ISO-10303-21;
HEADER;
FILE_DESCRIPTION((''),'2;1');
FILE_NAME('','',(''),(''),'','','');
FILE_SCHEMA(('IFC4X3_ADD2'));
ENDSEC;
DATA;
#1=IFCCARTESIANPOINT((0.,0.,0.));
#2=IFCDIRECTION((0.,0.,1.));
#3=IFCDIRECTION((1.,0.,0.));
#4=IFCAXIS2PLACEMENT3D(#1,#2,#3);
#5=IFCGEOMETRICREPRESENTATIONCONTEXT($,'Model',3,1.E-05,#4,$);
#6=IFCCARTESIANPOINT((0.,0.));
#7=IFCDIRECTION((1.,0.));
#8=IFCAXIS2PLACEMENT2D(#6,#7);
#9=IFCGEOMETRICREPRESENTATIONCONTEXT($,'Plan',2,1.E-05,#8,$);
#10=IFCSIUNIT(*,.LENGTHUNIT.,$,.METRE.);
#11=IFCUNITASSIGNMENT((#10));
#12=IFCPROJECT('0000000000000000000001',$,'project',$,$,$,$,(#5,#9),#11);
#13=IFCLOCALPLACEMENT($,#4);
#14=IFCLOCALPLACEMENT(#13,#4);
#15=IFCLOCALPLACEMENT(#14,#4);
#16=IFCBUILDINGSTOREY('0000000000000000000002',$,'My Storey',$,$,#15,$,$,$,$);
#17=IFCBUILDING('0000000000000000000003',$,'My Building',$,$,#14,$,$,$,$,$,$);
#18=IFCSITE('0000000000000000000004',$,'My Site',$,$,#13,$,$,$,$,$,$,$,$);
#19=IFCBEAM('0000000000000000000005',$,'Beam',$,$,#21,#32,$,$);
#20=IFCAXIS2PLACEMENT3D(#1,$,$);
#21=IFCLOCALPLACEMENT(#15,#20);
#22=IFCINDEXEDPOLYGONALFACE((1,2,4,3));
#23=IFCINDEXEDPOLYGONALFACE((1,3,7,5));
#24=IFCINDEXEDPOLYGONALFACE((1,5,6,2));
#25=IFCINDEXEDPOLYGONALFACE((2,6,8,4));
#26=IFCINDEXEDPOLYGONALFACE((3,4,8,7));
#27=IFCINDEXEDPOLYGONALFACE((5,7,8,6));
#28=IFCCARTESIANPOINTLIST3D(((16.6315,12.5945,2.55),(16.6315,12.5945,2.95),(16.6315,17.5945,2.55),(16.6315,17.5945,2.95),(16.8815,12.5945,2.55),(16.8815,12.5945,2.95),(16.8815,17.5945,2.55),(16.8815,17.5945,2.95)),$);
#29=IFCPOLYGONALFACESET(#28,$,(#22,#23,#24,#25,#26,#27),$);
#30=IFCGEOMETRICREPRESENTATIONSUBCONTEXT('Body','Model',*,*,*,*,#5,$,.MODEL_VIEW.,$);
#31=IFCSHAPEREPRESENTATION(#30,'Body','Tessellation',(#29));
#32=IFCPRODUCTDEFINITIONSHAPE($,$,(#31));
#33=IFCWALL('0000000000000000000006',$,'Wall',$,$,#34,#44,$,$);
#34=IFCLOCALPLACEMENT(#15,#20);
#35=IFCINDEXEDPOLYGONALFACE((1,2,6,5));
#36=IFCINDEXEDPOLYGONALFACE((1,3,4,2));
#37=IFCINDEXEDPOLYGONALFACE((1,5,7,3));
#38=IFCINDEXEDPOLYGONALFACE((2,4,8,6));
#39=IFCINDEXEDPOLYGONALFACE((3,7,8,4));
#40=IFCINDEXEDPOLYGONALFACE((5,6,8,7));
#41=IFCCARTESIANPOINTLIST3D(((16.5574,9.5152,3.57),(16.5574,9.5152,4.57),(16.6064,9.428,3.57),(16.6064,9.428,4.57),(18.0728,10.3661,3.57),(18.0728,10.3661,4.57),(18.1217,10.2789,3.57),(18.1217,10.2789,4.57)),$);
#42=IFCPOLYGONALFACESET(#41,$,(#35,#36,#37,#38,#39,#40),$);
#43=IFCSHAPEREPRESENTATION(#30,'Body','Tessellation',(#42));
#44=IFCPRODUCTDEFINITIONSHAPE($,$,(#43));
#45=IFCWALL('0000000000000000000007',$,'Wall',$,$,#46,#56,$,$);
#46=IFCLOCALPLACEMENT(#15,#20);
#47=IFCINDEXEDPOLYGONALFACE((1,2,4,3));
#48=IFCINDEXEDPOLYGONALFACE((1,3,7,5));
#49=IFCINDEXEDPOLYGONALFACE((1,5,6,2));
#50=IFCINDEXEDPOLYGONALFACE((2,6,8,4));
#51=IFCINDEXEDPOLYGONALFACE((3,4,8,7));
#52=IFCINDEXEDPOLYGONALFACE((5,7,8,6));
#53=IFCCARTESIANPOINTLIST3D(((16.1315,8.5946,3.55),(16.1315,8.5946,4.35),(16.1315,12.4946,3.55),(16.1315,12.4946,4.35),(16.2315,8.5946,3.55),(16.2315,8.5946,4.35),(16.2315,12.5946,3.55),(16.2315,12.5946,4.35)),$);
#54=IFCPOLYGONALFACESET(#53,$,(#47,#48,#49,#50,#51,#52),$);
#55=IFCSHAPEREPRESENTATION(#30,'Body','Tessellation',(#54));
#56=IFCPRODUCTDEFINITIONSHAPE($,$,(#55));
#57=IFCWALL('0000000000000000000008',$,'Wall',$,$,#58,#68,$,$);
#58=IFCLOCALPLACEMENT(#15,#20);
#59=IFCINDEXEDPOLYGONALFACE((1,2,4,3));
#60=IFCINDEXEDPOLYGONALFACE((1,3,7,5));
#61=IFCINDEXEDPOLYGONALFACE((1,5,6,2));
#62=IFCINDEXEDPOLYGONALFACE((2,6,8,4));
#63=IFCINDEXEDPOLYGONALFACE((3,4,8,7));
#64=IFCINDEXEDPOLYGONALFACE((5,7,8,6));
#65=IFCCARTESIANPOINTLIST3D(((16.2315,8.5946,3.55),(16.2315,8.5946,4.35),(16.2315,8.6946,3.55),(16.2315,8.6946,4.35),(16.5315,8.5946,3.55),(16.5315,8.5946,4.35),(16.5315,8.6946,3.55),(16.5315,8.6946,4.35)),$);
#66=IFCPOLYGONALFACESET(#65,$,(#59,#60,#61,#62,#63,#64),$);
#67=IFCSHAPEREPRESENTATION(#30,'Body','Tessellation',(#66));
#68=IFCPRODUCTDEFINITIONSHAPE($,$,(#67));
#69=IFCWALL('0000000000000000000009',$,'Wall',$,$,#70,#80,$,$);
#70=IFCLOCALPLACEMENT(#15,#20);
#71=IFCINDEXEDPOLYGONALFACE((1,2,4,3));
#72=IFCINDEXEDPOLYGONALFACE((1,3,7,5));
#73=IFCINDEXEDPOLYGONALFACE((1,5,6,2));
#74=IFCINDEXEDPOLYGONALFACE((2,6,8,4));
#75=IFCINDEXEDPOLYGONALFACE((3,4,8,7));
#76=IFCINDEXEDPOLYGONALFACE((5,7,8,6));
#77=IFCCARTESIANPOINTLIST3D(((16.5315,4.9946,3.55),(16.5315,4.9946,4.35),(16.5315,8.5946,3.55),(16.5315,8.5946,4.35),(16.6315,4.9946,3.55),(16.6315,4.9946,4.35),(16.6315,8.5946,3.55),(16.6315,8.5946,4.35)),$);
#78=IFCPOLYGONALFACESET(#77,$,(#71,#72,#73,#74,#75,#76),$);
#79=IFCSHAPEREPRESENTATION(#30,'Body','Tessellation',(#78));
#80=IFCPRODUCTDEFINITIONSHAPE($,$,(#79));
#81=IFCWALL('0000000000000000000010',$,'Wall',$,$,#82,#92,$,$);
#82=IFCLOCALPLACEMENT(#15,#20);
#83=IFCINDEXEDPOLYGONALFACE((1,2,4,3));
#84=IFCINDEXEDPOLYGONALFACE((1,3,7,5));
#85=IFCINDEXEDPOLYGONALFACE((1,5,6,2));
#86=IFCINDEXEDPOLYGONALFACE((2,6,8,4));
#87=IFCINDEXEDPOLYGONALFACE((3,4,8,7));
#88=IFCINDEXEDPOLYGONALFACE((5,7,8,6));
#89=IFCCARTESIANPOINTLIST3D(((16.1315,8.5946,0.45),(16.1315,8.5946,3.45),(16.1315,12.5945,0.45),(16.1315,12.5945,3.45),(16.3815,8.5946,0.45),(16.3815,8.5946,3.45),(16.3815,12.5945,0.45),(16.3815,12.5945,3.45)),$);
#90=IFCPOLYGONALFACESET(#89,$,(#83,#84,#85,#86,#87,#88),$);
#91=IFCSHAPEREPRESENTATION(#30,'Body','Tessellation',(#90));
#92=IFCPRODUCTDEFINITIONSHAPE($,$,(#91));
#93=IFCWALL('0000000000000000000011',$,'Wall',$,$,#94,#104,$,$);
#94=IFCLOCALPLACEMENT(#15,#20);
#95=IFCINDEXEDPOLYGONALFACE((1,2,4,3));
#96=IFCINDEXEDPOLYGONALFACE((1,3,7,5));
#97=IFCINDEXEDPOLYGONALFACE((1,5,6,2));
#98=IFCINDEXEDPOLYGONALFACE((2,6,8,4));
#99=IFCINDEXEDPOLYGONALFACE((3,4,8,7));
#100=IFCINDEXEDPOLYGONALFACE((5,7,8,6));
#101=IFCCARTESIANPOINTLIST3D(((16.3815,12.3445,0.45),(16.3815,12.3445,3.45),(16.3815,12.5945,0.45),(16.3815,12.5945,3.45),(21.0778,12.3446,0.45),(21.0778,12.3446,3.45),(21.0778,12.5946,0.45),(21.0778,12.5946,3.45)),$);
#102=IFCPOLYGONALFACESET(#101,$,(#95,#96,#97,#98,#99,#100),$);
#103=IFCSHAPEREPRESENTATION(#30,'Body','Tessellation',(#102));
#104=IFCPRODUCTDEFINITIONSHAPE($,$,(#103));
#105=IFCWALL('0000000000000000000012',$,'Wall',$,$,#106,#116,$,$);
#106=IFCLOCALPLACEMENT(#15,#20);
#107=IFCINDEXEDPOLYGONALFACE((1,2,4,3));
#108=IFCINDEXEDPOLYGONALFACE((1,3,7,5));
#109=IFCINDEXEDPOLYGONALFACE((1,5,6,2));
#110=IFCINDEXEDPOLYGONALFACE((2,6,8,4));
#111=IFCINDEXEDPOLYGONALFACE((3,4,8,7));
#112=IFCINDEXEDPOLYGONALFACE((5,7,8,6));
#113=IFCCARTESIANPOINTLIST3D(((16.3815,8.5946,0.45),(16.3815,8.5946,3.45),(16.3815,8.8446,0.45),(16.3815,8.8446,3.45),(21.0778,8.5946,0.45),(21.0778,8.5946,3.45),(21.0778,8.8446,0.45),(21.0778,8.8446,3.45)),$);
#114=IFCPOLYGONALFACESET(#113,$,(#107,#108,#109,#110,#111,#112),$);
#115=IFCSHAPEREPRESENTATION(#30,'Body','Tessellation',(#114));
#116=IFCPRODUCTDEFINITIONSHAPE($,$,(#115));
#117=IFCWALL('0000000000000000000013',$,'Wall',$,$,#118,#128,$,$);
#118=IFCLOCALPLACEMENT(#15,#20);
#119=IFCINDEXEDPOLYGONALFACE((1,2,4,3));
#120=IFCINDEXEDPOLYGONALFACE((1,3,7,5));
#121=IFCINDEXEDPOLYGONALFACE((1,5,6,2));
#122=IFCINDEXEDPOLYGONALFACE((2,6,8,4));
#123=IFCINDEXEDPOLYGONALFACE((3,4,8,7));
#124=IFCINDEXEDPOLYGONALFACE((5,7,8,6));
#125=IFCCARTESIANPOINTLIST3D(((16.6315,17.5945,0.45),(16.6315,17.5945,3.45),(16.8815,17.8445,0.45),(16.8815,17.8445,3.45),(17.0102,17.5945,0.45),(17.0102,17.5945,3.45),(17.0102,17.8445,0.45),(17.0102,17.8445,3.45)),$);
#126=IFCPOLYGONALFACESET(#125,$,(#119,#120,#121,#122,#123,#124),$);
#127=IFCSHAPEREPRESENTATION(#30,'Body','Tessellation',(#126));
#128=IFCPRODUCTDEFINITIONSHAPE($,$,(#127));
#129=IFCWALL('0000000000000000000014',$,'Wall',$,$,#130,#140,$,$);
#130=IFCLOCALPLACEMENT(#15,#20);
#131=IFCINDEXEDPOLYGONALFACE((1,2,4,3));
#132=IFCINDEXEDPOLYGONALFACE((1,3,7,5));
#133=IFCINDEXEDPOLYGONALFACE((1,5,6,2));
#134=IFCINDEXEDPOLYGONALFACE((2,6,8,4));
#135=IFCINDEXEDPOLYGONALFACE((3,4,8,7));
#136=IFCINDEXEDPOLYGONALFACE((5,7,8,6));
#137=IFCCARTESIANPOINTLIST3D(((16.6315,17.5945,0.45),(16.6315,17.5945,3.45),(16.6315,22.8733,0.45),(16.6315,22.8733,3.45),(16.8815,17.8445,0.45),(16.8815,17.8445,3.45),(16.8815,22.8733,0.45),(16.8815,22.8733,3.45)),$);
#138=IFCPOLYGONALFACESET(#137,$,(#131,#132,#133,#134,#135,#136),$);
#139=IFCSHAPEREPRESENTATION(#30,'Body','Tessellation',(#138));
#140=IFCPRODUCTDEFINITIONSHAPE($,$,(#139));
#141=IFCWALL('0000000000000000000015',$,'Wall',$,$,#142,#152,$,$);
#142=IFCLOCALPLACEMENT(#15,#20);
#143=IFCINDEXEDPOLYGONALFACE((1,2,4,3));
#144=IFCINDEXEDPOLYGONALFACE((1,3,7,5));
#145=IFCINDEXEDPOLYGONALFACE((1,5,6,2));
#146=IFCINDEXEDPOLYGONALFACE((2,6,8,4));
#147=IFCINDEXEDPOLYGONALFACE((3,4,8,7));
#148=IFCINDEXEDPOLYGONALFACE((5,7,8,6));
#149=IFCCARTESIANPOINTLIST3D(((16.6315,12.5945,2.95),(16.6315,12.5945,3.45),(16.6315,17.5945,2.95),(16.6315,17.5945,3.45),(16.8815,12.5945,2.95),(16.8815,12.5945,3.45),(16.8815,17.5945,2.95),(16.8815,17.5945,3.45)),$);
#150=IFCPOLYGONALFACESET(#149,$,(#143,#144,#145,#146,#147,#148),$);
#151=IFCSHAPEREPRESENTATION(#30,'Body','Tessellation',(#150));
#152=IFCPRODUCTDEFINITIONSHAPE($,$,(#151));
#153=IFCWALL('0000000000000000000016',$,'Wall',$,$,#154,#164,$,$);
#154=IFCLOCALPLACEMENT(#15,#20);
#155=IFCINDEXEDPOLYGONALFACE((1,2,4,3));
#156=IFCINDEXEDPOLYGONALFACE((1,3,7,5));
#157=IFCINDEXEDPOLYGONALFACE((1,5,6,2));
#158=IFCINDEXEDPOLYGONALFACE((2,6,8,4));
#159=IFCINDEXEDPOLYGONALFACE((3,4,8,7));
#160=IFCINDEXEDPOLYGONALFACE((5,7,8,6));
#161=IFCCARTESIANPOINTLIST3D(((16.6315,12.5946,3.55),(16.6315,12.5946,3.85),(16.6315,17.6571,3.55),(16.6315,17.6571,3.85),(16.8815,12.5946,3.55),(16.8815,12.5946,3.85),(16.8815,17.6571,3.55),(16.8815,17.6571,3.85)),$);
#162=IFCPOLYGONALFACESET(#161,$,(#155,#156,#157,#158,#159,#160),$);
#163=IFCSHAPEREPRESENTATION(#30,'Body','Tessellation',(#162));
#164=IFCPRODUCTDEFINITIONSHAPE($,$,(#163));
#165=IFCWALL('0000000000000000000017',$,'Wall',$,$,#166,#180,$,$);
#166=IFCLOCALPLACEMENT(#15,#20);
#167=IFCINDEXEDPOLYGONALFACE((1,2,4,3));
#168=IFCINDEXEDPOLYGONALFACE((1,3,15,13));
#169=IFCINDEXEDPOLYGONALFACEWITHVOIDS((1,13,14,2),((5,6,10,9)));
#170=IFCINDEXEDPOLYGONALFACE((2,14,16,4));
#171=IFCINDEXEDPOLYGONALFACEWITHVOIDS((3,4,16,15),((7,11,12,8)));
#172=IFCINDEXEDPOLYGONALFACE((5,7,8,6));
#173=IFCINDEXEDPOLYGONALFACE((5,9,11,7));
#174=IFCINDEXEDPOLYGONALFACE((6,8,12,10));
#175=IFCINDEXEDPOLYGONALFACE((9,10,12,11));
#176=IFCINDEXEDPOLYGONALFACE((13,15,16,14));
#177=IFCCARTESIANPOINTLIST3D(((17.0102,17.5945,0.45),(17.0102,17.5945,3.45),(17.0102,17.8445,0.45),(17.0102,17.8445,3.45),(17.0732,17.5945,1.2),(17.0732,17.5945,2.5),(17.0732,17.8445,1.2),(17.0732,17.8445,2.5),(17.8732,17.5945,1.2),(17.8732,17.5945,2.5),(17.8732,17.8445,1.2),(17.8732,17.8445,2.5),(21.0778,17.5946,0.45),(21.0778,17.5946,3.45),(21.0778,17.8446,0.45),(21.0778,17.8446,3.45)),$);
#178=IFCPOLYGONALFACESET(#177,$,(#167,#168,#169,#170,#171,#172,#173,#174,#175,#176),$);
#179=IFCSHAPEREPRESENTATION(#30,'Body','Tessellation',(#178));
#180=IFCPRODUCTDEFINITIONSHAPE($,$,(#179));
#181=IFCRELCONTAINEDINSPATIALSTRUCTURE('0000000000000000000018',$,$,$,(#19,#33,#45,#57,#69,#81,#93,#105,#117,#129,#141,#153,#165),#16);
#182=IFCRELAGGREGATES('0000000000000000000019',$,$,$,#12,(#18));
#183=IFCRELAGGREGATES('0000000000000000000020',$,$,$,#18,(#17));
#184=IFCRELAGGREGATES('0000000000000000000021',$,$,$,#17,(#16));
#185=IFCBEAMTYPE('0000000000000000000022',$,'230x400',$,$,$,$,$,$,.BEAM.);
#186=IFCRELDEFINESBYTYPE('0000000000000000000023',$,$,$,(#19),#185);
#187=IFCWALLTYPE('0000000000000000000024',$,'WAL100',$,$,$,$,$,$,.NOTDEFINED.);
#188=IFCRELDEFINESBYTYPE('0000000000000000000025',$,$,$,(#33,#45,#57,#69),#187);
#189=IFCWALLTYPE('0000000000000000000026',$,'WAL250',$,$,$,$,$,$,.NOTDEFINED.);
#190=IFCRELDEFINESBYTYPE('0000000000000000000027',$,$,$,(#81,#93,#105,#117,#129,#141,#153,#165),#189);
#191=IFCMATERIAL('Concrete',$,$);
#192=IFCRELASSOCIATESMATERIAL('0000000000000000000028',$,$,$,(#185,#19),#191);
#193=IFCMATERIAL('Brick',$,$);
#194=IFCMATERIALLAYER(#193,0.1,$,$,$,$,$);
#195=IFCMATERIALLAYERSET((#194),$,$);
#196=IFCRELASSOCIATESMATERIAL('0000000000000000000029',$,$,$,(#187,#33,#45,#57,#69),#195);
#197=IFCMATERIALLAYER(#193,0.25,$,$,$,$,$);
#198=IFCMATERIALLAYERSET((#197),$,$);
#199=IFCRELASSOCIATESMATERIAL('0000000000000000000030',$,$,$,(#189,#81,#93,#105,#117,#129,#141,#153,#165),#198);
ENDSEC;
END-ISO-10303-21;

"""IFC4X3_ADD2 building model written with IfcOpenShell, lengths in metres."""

from ifc_helpers import new_model, si_unit, frame, origin_with_axes, origin_2d_with_axis, place, context, subcontext, project, spatial, line, indexed_curve, rectangle, outline, extrude, source, transform, mapped, material, layer, layer_set, layer_usage, material_profile, profile_set, profile_usage, type_object, element, save


model = new_model("IFC4X3_ADD2")

# Units and contexts
model_context = context("Model", 3, precision=1e-05, world=origin_with_axes())
plan_context = context("Plan", 2, precision=1e-05, world=origin_2d_with_axis())
body_context = subcontext(model_context, "Body", "Model", "MODEL_VIEW")
ifc_project = project(units=[si_unit("LENGTHUNIT", "METRE")], contexts=[model_context, plan_context])

# Site, building, storey
site_placement = place(None, origin_with_axes())
site = spatial("IfcSite", under=ifc_project, at=site_placement, Name="My Site")
building_placement = place(site_placement, origin_with_axes())
building = spatial("IfcBuilding", under=site, at=building_placement, Name="My Building")
storey_placement = place(building_placement, origin_with_axes())
storey = spatial("IfcBuildingStorey", under=building, at=storey_placement, Name="My Storey")

# Beam
ifc_material_1 = material(Name="Concrete")
ifc_material_profile = material_profile(ifc_material_1, rectangle(XDim=0.25, YDim=0.4))
ifc_profile_set = profile_set([ifc_material_profile])
ifc_profile_usage = profile_usage(ifc_profile_set, cardinal=5)
beam_type = type_object("IfcBeamType", Name="230x400", PredefinedType="BEAM", material=ifc_profile_set)
beam_placement = place(storey_placement, frame((16.7565, 12.5945, 2.75), z_axis=(0.0, 1.0, 0.0), x_axis=(-1.0, 0.0, 0.0)))
element("IfcBeam", 1, at=beam_placement, inside=storey, type_object=beam_type, material=ifc_profile_usage, Name="Beam", context=body_context, shape_type="SweptSolid", body=[
    extrude(rectangle(XDim=0.25, YDim=0.4), origin_with_axes(), (0.0, 0.0, 1.0), 5.0),
])

# Walls
ifc_material_2 = material(Name="Brick")
ifc_layer_1 = layer(ifc_material_2, 0.1)
ifc_layer_set_1 = layer_set([ifc_layer_1])
ifc_layer_usage_1 = layer_usage(ifc_layer_set_1, "AXIS2", "POSITIVE", 0.0)
wall_type_1 = type_object("IfcWallType", Name="WAL100", PredefinedType="NOTDEFINED", material=ifc_layer_set_1)
wall_1_placement = place(storey_placement, frame((16.6064, 9.428, 3.57), z_axis=(0.0, 0.0, 1.0), x_axis=(0.871953, 0.489589, 0.0)))
element("IfcWall", 2, at=wall_1_placement, inside=storey, type_object=wall_type_1, material=ifc_layer_usage_1, Name="Wall", context=body_context, shape_type="SweptSolid", body=[
    extrude(outline(indexed_curve([(0.0, 0.0), (0.0, 0.1), (1.7379, 0.1), (1.7379, 0.0)], segments=[line(1, 2, 3, 4, 1)])), origin_with_axes(), (0.0, 0.0, 1.0), 1.0),
])
ifc_layer_usage_2 = layer_usage(ifc_layer_set_1, "AXIS2", "POSITIVE", 0.0)
wall_2_placement = place(storey_placement, frame((16.2315, 8.5946, 3.55), z_axis=(0.0, 0.0, 1.0), x_axis=(-0.000006, 1.0, 0.0)))
element("IfcWall", 3, at=wall_2_placement, inside=storey, type_object=wall_type_1, material=ifc_layer_usage_2, Name="Wall", context=body_context, shape_type="SweptSolid", body=[
    extrude(outline(indexed_curve([(0.0, 0.0), (0.0, 0.1), (3.9, 0.1), (4.0, 0.0)], segments=[line(1, 2, 3, 4, 1)])), origin_with_axes(), (0.0, 0.0, 1.0), 0.8),
])
ifc_layer_usage_3 = layer_usage(ifc_layer_set_1, "AXIS2", "POSITIVE", 0.0)
wall_3_placement = place(storey_placement, frame((16.2315, 8.5946, 3.55), z_axis=(0.0, 0.0, 1.0), x_axis=(1.0, 0.000005, 0.0)))
element("IfcWall", 4, at=wall_3_placement, inside=storey, type_object=wall_type_1, material=ifc_layer_usage_3, Name="Wall", context=body_context, shape_type="SweptSolid", body=[
    extrude(outline(indexed_curve([(0.0, 0.0), (0.0, 0.1), (0.3, 0.1), (0.3, 0.0)], segments=[line(1, 2, 3, 4, 1)])), origin_with_axes(), (0.0, 0.0, 1.0), 0.8),
])
ifc_layer_usage_4 = layer_usage(ifc_layer_set_1, "AXIS2", "POSITIVE", 0.0)
wall_4_placement = place(storey_placement, frame((16.5315, 8.5946, 3.55), z_axis=(0.0, 0.0, 1.0), x_axis=(0.000005, -1.0, 0.0)))
element("IfcWall", 5, at=wall_4_placement, inside=storey, type_object=wall_type_1, material=ifc_layer_usage_4, Name="Wall", context=body_context, shape_type="SweptSolid", body=[
    extrude(outline(indexed_curve([(0.0, 0.0), (0.0, 0.1), (3.6, 0.1), (3.6, 0.0)], segments=[line(1, 2, 3, 4, 1)])), origin_with_axes(), (0.0, 0.0, 1.0), 0.8),
])
ifc_layer_2 = layer(ifc_material_2, 0.25)
ifc_layer_set_2 = layer_set([ifc_layer_2])
ifc_layer_usage_5 = layer_usage(ifc_layer_set_2, "AXIS2", "NEGATIVE", 0.0)
wall_type_2 = type_object("IfcWallType", Name="WAL250", PredefinedType="NOTDEFINED", material=ifc_layer_set_2)
wall_5_placement = place(storey_placement, frame((16.1315, 8.5946, 0.45), z_axis=(0.0, 0.0, 1.0), x_axis=(0.0, 1.0, 0.0)))
element("IfcWall", 6, at=wall_5_placement, inside=storey, type_object=wall_type_2, material=ifc_layer_usage_5, Name="Wall", context=body_context, shape_type="SweptSolid", body=[
    extrude(outline(indexed_curve([(0.0, -0.25), (0.0, 0.0), (4.0, 0.0), (4.0, -0.25)], segments=[line(1, 2, 3, 4, 1)])), origin_with_axes(), (0.0, 0.0, 1.0), 3.0),
])
ifc_layer_usage_6 = layer_usage(ifc_layer_set_2, "AXIS2", "POSITIVE", 0.0)
wall_6_placement = place(storey_placement, frame((16.3815, 12.3445, 0.45), z_axis=(0.0, 0.0, 1.0), x_axis=(1.0, 0.000006, 0.0)))
element("IfcWall", 7, at=wall_6_placement, inside=storey, type_object=wall_type_2, material=ifc_layer_usage_6, Name="Wall", context=body_context, shape_type="SweptSolid", body=[
    extrude(outline(indexed_curve([(0.0, 0.0), (0.0, 0.25), (4.6964, 0.25), (4.6964, 0.0)], segments=[line(1, 2, 3, 4, 1)])), origin_with_axes(), (0.0, 0.0, 1.0), 3.0),
])
ifc_layer_usage_7 = layer_usage(ifc_layer_set_2, "AXIS2", "POSITIVE", 0.0)
wall_7_placement = place(storey_placement, frame((16.3815, 8.5946, 0.45), z_axis=(0.0, 0.0, 1.0), x_axis=(1.0, 0.000006, 0.0)))
element("IfcWall", 8, at=wall_7_placement, inside=storey, type_object=wall_type_2, material=ifc_layer_usage_7, Name="Wall", context=body_context, shape_type="SweptSolid", body=[
    extrude(outline(indexed_curve([(0.0, 0.0), (0.0, 0.25), (4.6964, 0.25), (4.6964, 0.0)], segments=[line(1, 2, 3, 4, 1)])), origin_with_axes(), (0.0, 0.0, 1.0), 3.0),
])
ifc_layer_usage_8 = layer_usage(ifc_layer_set_2, "AXIS2", "POSITIVE", 0.0)
wall_8_placement = place(storey_placement, frame((16.8815, 17.5945, 0.45), z_axis=(0.0, 0.0, 1.0), x_axis=(1.0, 0.000006, 0.0)))
element("IfcWall", 9, at=wall_8_placement, inside=storey, type_object=wall_type_2, material=ifc_layer_usage_8, Name="Wall", context=body_context, shape_type="SweptSolid", body=[
    extrude(outline(indexed_curve([(-0.25, 0.0), (0.0, 0.25), (0.1287, 0.25), (0.1287, 0.0)], segments=[line(1, 2, 3, 4, 1)])), origin_with_axes(), (0.0, 0.0, 1.0), 3.0),
])
ifc_layer_usage_9 = layer_usage(ifc_layer_set_2, "AXIS2", "POSITIVE", 0.0)
wall_9_placement = place(storey_placement, frame((16.8815, 17.5945, 0.45), z_axis=(0.0, 0.0, 1.0), x_axis=(-0.000006, 1.0, 0.0)))
element("IfcWall", 10, at=wall_9_placement, inside=storey, type_object=wall_type_2, material=ifc_layer_usage_9, Name="Wall", context=body_context, shape_type="SweptSolid", body=[
    extrude(outline(indexed_curve([(0.25, 0.0), (0.0, 0.25), (5.2788, 0.25), (5.2788, 0.0)], segments=[line(1, 2, 3, 4, 1)])), origin_with_axes(), (0.0, 0.0, 1.0), 3.0),
])
ifc_layer_usage_10 = layer_usage(ifc_layer_set_2, "AXIS2", "POSITIVE", 0.0)
wall_10_placement = place(storey_placement, frame((16.8815, 12.5945, 2.95), z_axis=(0.0, 0.0, 1.0), x_axis=(-0.000006, 1.0, 0.0)))
element("IfcWall", 11, at=wall_10_placement, inside=storey, type_object=wall_type_2, material=ifc_layer_usage_10, Name="Wall", context=body_context, shape_type="SweptSolid", body=[
    extrude(outline(indexed_curve([(0.0, 0.0), (0.0, 0.25), (5.0, 0.25), (5.0, 0.0)], segments=[line(1, 2, 3, 4, 1)])), origin_with_axes(), (0.0, 0.0, 1.0), 0.5),
])
ifc_layer_usage_11 = layer_usage(ifc_layer_set_2, "AXIS2", "POSITIVE", 0.0)
wall_11_placement = place(storey_placement, frame((16.8815, 12.5946, 3.55), z_axis=(0.0, 0.0, 1.0), x_axis=(-0.000006, 1.0, 0.0)))
element("IfcWall", 12, at=wall_11_placement, inside=storey, type_object=wall_type_2, material=ifc_layer_usage_11, Name="Wall", context=body_context, shape_type="SweptSolid", body=[
    extrude(outline(indexed_curve([(0.0, 0.0), (0.0, 0.25), (5.0625, 0.25), (5.0625, 0.0)], segments=[line(1, 2, 3, 4, 1)])), origin_with_axes(), (0.0, 0.0, 1.0), 0.3),
])

# Wall, opening
ifc_layer_usage_12 = layer_usage(ifc_layer_set_2, "AXIS2", "POSITIVE", 0.0)
wall_12_placement = place(storey_placement, frame((17.0102, 17.5945, 0.45), z_axis=(0.0, 0.0, 1.0), x_axis=(1.0, 0.000006, 0.0)))
wall_12 = element("IfcWall", 13, at=wall_12_placement, inside=storey, type_object=wall_type_2, material=ifc_layer_usage_12, Name="Wall", context=body_context, shape_type="SweptSolid", body=[
    extrude(outline(indexed_curve([(0.0, 0.0), (0.0, 0.25), (4.0676, 0.25), (4.0676, 0.0)], segments=[line(1, 2, 3, 4, 1)])), origin_with_axes(), (0.0, 0.0, 1.0), 3.0),
])
shared_shape = source(origin_with_axes(), body_context, "Body", "SweptSolid", [
    extrude(outline(indexed_curve([(0.0, 0.0), (0.8, 0.0), (0.8, 1.3), (0.0, 1.3)], segments=[line(1, 2, 3, 4, 1)])), frame((0.0, -0.6, 0.0), z_axis=(0.0, -1.0, 0.0), x_axis=(1.0, 0.0, 0.0)), (0.0, 0.0, -1.0), 1.2),
])
opening_placement = place(wall_12_placement, frame((0.063, 0.0, 0.75), z_axis=(0.0, 0.0, 1.0), x_axis=(1.0, 0.0, 0.0)))
element("IfcOpeningElement", 14, at=opening_placement, cuts=wall_12, PredefinedType="OPENING", context=body_context, shape_type="MappedRepresentation", body=[
    mapped(shared_shape, transform((0.0, 0.0, 0.0), x_axis=(1.0, 0.0, 0.0), y_axis=(0.0, 1.0, 0.0), z_axis=(0.0, 0.0, 1.0), scale=1.0)),
])

save(model, "model.ifc")
